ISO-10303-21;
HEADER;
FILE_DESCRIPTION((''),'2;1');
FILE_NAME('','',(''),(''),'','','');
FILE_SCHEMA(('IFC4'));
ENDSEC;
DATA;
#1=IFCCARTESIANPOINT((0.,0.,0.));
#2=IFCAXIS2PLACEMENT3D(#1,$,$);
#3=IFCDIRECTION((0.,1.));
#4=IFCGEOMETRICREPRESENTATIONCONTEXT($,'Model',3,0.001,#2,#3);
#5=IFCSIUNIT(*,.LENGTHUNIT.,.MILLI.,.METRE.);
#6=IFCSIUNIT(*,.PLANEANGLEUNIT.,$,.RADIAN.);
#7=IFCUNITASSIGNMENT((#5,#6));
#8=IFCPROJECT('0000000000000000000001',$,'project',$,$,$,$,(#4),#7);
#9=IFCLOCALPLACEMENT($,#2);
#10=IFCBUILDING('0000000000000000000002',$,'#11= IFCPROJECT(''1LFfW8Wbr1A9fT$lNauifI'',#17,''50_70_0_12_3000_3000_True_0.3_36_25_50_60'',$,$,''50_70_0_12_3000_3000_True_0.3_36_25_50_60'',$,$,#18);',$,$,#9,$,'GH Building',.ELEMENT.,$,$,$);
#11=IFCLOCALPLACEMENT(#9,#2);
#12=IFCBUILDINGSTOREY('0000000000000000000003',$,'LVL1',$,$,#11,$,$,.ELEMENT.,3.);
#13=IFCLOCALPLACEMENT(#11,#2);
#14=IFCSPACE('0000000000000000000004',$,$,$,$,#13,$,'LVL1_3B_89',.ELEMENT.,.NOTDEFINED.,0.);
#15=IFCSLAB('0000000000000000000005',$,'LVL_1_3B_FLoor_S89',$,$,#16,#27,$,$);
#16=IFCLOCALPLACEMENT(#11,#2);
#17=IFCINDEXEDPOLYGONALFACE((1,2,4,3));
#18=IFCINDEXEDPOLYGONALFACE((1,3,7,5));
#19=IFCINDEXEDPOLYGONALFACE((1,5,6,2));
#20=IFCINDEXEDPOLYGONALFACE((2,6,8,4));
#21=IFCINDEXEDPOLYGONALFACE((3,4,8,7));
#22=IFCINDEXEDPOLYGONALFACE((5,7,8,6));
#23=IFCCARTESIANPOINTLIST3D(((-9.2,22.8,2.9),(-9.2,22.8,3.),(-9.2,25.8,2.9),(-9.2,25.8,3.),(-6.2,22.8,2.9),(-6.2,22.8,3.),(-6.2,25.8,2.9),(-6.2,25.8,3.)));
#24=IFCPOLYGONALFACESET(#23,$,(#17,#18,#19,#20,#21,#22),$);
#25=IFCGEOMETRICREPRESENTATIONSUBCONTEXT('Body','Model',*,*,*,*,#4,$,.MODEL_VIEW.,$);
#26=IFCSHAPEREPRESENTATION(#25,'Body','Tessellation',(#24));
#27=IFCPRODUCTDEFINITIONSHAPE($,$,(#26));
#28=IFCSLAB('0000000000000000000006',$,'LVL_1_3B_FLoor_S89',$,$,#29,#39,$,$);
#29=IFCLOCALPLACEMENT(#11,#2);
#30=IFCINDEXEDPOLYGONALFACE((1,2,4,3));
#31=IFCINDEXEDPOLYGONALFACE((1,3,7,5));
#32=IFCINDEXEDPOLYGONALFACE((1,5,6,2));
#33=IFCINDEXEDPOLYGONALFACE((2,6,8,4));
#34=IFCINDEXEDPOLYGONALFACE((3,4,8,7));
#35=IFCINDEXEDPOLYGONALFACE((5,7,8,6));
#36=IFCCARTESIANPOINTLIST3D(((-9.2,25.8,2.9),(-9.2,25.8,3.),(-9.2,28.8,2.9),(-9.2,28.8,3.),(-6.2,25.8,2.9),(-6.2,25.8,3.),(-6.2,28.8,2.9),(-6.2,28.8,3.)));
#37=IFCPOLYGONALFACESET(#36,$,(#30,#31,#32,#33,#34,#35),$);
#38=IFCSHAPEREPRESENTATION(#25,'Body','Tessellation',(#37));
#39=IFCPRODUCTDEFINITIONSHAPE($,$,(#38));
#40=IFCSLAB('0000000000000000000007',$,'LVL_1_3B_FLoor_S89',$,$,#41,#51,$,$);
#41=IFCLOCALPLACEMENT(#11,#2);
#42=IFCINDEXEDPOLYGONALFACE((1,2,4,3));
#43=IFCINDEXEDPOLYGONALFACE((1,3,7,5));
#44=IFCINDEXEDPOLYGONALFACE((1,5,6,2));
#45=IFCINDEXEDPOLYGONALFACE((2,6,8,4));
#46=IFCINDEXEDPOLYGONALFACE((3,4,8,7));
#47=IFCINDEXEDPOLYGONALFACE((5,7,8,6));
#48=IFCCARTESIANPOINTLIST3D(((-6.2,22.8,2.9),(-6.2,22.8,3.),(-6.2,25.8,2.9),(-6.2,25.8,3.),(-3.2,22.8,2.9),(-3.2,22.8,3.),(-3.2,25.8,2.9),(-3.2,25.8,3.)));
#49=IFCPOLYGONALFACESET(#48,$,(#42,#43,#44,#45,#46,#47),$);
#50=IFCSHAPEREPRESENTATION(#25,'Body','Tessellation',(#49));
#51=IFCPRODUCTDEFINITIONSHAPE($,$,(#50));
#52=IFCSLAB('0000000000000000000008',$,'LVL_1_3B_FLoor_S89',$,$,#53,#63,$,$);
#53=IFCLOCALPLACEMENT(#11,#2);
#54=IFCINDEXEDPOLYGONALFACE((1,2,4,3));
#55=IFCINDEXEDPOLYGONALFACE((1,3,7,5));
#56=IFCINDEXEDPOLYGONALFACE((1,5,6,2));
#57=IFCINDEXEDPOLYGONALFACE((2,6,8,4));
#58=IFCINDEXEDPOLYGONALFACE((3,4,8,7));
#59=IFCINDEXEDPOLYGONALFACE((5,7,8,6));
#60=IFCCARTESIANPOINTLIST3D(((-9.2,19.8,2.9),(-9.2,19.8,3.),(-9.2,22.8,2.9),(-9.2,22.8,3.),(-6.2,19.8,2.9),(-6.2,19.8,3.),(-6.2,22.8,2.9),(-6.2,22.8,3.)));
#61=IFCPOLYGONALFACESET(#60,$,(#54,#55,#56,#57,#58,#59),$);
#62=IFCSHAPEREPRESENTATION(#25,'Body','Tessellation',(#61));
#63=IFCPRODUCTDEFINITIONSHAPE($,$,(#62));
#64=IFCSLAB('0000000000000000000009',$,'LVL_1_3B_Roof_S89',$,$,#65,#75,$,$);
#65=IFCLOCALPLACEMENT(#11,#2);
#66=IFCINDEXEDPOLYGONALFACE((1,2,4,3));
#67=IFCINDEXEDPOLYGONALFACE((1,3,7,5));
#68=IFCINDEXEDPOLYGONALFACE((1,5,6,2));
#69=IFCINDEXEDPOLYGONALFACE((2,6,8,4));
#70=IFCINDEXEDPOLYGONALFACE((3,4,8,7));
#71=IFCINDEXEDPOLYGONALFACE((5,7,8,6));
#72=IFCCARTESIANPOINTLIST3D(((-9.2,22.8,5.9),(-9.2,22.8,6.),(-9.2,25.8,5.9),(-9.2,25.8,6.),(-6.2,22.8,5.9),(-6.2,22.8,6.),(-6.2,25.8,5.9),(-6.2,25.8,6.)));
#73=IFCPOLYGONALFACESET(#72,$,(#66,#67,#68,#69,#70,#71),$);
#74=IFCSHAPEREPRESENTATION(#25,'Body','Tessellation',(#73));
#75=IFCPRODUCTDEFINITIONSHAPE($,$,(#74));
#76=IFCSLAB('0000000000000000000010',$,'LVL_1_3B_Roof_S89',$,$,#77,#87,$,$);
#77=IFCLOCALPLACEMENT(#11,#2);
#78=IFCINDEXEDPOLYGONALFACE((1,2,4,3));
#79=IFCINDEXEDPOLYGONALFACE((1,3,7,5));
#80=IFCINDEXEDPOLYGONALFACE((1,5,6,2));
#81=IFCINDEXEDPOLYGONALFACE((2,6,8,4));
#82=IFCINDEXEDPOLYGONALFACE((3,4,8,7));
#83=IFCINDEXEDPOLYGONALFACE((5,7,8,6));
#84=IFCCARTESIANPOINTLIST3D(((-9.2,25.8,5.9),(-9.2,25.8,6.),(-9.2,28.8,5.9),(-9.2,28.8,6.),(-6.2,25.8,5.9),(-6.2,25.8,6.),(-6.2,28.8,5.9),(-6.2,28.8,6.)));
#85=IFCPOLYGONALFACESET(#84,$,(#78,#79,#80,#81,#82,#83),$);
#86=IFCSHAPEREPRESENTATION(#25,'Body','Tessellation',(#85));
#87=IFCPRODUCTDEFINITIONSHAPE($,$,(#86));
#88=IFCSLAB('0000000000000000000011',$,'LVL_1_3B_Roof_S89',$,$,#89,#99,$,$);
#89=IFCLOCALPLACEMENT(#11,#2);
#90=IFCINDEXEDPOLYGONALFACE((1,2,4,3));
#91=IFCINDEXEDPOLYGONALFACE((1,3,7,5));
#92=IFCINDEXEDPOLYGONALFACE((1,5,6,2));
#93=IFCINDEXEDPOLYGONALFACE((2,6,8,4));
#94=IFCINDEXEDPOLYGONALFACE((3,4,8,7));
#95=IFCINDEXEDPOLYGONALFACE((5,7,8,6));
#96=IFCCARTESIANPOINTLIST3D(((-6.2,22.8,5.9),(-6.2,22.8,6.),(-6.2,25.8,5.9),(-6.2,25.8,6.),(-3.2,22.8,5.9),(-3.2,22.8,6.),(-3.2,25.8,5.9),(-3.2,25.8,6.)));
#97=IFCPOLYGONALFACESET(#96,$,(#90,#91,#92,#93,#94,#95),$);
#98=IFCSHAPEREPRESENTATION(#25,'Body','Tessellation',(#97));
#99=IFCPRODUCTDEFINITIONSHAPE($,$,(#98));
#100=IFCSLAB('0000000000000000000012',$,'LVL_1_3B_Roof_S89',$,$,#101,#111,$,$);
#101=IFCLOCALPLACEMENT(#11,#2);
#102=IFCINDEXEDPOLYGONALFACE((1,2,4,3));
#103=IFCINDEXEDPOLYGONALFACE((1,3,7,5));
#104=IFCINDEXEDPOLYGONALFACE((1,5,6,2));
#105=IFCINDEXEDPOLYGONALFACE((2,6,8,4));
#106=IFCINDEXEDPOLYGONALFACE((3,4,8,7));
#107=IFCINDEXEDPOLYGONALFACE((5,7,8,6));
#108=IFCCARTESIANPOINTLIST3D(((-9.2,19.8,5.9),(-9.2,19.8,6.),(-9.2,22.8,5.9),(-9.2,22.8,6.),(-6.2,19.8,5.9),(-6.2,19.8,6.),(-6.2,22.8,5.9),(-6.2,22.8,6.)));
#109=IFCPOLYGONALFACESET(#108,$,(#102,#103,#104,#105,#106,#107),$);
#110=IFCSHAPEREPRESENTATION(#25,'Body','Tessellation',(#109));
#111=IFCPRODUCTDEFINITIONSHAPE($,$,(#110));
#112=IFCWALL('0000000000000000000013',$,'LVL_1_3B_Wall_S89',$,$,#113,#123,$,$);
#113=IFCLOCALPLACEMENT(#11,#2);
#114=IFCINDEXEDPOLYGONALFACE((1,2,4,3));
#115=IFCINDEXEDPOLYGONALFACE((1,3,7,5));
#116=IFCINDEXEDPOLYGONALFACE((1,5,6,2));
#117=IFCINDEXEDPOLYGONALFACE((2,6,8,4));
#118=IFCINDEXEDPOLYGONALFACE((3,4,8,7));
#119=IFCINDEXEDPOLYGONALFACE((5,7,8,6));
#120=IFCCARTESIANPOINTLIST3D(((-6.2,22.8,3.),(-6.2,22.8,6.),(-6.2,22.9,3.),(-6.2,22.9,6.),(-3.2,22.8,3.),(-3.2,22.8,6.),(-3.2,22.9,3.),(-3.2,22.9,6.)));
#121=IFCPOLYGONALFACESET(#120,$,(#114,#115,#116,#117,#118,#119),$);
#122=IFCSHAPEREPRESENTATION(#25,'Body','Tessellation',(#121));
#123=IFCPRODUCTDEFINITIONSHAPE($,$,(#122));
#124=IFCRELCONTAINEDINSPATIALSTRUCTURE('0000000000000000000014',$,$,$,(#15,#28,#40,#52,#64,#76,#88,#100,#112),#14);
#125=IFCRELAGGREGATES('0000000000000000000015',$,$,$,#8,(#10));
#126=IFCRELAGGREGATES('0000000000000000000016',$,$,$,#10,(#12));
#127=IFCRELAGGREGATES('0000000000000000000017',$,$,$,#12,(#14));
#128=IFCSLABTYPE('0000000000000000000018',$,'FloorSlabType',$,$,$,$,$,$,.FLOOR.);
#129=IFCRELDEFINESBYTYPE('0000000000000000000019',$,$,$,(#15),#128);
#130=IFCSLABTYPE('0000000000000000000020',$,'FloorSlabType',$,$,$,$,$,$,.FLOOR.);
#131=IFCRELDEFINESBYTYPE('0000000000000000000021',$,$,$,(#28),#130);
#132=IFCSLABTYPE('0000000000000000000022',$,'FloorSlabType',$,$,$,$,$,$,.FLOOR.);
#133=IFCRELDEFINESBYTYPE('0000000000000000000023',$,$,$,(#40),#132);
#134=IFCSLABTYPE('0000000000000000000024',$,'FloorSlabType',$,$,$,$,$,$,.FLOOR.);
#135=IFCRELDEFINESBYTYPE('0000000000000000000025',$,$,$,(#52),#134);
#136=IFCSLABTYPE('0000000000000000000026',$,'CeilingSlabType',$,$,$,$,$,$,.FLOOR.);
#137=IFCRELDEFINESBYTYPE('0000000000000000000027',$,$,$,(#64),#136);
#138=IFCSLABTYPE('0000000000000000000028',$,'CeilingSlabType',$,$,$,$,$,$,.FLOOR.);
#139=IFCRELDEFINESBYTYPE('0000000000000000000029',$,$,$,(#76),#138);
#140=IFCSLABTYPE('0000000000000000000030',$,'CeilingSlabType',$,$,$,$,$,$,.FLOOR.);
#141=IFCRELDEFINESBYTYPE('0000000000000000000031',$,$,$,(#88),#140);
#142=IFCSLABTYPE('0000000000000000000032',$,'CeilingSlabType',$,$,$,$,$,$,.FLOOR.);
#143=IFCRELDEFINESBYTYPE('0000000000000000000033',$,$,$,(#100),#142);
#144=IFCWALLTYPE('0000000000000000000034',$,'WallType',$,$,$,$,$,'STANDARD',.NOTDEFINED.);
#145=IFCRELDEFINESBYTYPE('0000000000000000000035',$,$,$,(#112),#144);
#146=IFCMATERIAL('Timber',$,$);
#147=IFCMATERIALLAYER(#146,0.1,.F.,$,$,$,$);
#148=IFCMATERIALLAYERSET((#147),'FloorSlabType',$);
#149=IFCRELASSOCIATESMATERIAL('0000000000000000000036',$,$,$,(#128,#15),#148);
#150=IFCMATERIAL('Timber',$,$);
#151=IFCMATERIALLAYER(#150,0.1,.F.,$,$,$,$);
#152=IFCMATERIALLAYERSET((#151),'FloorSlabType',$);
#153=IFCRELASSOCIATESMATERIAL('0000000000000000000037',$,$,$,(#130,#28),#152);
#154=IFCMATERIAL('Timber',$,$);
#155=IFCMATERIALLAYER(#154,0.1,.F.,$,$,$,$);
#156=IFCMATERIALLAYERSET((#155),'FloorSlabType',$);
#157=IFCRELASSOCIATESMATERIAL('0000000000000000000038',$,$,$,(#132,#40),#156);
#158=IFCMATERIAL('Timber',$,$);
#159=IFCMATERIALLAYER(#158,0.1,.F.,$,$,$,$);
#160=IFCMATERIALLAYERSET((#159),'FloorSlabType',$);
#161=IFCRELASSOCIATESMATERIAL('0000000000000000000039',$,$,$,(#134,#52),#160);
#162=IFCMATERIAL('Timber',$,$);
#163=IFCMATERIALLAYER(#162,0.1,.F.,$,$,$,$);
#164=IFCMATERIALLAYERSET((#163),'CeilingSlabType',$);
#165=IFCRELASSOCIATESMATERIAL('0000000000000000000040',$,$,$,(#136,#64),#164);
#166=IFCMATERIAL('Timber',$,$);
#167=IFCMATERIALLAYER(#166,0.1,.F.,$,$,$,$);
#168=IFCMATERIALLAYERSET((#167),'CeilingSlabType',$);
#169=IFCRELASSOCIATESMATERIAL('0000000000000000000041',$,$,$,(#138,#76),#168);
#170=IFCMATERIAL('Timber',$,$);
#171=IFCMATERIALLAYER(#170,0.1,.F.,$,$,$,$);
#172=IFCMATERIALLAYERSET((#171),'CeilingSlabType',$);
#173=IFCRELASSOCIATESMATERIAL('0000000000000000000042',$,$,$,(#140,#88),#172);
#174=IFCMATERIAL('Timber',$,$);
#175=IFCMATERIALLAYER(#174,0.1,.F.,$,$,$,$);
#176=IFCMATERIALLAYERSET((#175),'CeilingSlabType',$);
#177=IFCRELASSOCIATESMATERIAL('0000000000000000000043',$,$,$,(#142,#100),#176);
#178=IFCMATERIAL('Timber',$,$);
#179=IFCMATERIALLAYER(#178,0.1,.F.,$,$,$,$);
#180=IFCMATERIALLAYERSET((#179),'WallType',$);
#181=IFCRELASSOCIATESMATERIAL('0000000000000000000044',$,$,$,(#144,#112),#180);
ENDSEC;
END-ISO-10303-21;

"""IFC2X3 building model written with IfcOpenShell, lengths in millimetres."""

from ifc_helpers import new_model, si_unit, direction, frame, frame_2d, origin, place, context, subcontext, project, spatial, rectangle, extrude, material, layer, layer_set, layer_usage, type_object, element, save


model = new_model("IFC2X3")

# Units and contexts
model_context = context("Model", 3, precision=0.001, world=origin(), true_north=direction((0.0, 1.0)))
body_context = subcontext(model_context, "Body", "Model", "MODEL_VIEW")
ifc_project = project(units=[si_unit("LENGTHUNIT", "METRE", prefix="MILLI"), si_unit("PLANEANGLEUNIT", "RADIAN")], contexts=[model_context])

# Building, storey, space
building_placement = place(None, origin())
building = spatial("IfcBuilding", under=ifc_project, at=building_placement, Name="#11= IFCPROJECT('1LFfW8Wbr1A9fT$lNauifI',#17,'50_70_0_12_3000_3000_True_0.3_36_25_50_60',$,$,'50_70_0_12_3000_3000_True_0.3_36_25_50_60',$,$,#18);", LongName="GH Building", CompositionType="ELEMENT")
storey_placement = place(building_placement, origin())
storey = spatial("IfcBuildingStorey", under=building, at=storey_placement, Name="LVL1", CompositionType="ELEMENT", Elevation=3.0)
space_placement = place(storey_placement, origin())
space = spatial("IfcSpace", under=storey, at=space_placement, LongName="LVL1_3B_89", CompositionType="ELEMENT", InteriorOrExteriorSpace="NOTDEFINED", ElevationWithFlooring=0.0)

# Slabs
ifc_material_1 = material(Name="Timber")
ifc_layer_1 = layer(ifc_material_1, 0.1, ventilated=False)
ifc_layer_set_1 = layer_set([ifc_layer_1], Name="FloorSlabType")
ifc_layer_usage_1 = layer_usage(ifc_layer_set_1, "AXIS3", "NEGATIVE", -0.1)
slab_type_1 = type_object("IfcSlabType", Name="FloorSlabType", PredefinedType="FLOOR", material=ifc_layer_set_1)
slab_1_placement = place(space_placement, frame((-6.2, 22.8, 2.9), z_axis=(0.0, 0.0, 1.0), x_axis=(0.0, 1.0, 0.0)))
element("IfcSlab", 1, at=slab_1_placement, inside=space, type_object=slab_type_1, material=ifc_layer_usage_1, Name="LVL_1_3B_FLoor_S89", context=body_context, shape_type="SweptSolid", body=[
    extrude(rectangle(XDim=3.0, YDim=3.0, at=frame_2d((1.5, 1.5))), origin(), (0.0, 0.0, 1.0), 0.1),
])
ifc_material_2 = material(Name="Timber")
ifc_layer_2 = layer(ifc_material_2, 0.1, ventilated=False)
ifc_layer_set_2 = layer_set([ifc_layer_2], Name="FloorSlabType")
ifc_layer_usage_2 = layer_usage(ifc_layer_set_2, "AXIS3", "NEGATIVE", -0.1)
slab_type_2 = type_object("IfcSlabType", Name="FloorSlabType", PredefinedType="FLOOR", material=ifc_layer_set_2)
slab_2_placement = place(space_placement, frame((-6.2, 25.8, 2.9), z_axis=(0.0, 0.0, 1.0), x_axis=(0.0, 1.0, 0.0)))
element("IfcSlab", 2, at=slab_2_placement, inside=space, type_object=slab_type_2, material=ifc_layer_usage_2, Name="LVL_1_3B_FLoor_S89", context=body_context, shape_type="SweptSolid", body=[
    extrude(rectangle(XDim=3.0, YDim=3.0, at=frame_2d((1.5, 1.5))), origin(), (0.0, 0.0, 1.0), 0.1),
])
ifc_material_3 = material(Name="Timber")
ifc_layer_3 = layer(ifc_material_3, 0.1, ventilated=False)
ifc_layer_set_3 = layer_set([ifc_layer_3], Name="FloorSlabType")
ifc_layer_usage_3 = layer_usage(ifc_layer_set_3, "AXIS3", "NEGATIVE", -0.1)
slab_type_3 = type_object("IfcSlabType", Name="FloorSlabType", PredefinedType="FLOOR", material=ifc_layer_set_3)
slab_3_placement = place(space_placement, frame((-3.2, 22.8, 2.9), z_axis=(0.0, 0.0, 1.0), x_axis=(0.0, 1.0, 0.0)))
element("IfcSlab", 3, at=slab_3_placement, inside=space, type_object=slab_type_3, material=ifc_layer_usage_3, Name="LVL_1_3B_FLoor_S89", context=body_context, shape_type="SweptSolid", body=[
    extrude(rectangle(XDim=3.0, YDim=3.0, at=frame_2d((1.5, 1.5))), origin(), (0.0, 0.0, 1.0), 0.1),
])
ifc_material_4 = material(Name="Timber")
ifc_layer_4 = layer(ifc_material_4, 0.1, ventilated=False)
ifc_layer_set_4 = layer_set([ifc_layer_4], Name="FloorSlabType")
ifc_layer_usage_4 = layer_usage(ifc_layer_set_4, "AXIS3", "NEGATIVE", -0.1)
slab_type_4 = type_object("IfcSlabType", Name="FloorSlabType", PredefinedType="FLOOR", material=ifc_layer_set_4)
slab_4_placement = place(space_placement, frame((-6.2, 19.8, 2.9), z_axis=(0.0, 0.0, 1.0), x_axis=(0.0, 1.0, 0.0)))
element("IfcSlab", 4, at=slab_4_placement, inside=space, type_object=slab_type_4, material=ifc_layer_usage_4, Name="LVL_1_3B_FLoor_S89", context=body_context, shape_type="SweptSolid", body=[
    extrude(rectangle(XDim=3.0, YDim=3.0, at=frame_2d((1.5, 1.5))), origin(), (0.0, 0.0, 1.0), 0.1),
])
ifc_material_5 = material(Name="Timber")
ifc_layer_5 = layer(ifc_material_5, 0.1, ventilated=False)
ifc_layer_set_5 = layer_set([ifc_layer_5], Name="CeilingSlabType")
ifc_layer_usage_5 = layer_usage(ifc_layer_set_5, "AXIS3", "NEGATIVE", -0.1)
slab_type_5 = type_object("IfcSlabType", Name="CeilingSlabType", PredefinedType="FLOOR", material=ifc_layer_set_5)
slab_5_placement = place(space_placement, frame((-6.2, 22.8, 5.9), z_axis=(0.0, 0.0, 1.0), x_axis=(0.0, 1.0, 0.0)))
element("IfcSlab", 5, at=slab_5_placement, inside=space, type_object=slab_type_5, material=ifc_layer_usage_5, Name="LVL_1_3B_Roof_S89", context=body_context, shape_type="SweptSolid", body=[
    extrude(rectangle(XDim=3.0, YDim=3.0, at=frame_2d((1.5, 1.5))), origin(), (0.0, 0.0, 1.0), 0.1),
])
ifc_material_6 = material(Name="Timber")
ifc_layer_6 = layer(ifc_material_6, 0.1, ventilated=False)
ifc_layer_set_6 = layer_set([ifc_layer_6], Name="CeilingSlabType")
ifc_layer_usage_6 = layer_usage(ifc_layer_set_6, "AXIS3", "NEGATIVE", -0.1)
slab_type_6 = type_object("IfcSlabType", Name="CeilingSlabType", PredefinedType="FLOOR", material=ifc_layer_set_6)
slab_6_placement = place(space_placement, frame((-6.2, 25.8, 5.9), z_axis=(0.0, 0.0, 1.0), x_axis=(0.0, 1.0, 0.0)))
element("IfcSlab", 6, at=slab_6_placement, inside=space, type_object=slab_type_6, material=ifc_layer_usage_6, Name="LVL_1_3B_Roof_S89", context=body_context, shape_type="SweptSolid", body=[
    extrude(rectangle(XDim=3.0, YDim=3.0, at=frame_2d((1.5, 1.5))), origin(), (0.0, 0.0, 1.0), 0.1),
])
ifc_material_7 = material(Name="Timber")
ifc_layer_7 = layer(ifc_material_7, 0.1, ventilated=False)
ifc_layer_set_7 = layer_set([ifc_layer_7], Name="CeilingSlabType")
ifc_layer_usage_7 = layer_usage(ifc_layer_set_7, "AXIS3", "NEGATIVE", -0.1)
slab_type_7 = type_object("IfcSlabType", Name="CeilingSlabType", PredefinedType="FLOOR", material=ifc_layer_set_7)
slab_7_placement = place(space_placement, frame((-3.2, 22.8, 5.9), z_axis=(0.0, 0.0, 1.0), x_axis=(0.0, 1.0, 0.0)))
element("IfcSlab", 7, at=slab_7_placement, inside=space, type_object=slab_type_7, material=ifc_layer_usage_7, Name="LVL_1_3B_Roof_S89", context=body_context, shape_type="SweptSolid", body=[
    extrude(rectangle(XDim=3.0, YDim=3.0, at=frame_2d((1.5, 1.5))), origin(), (0.0, 0.0, 1.0), 0.1),
])
ifc_material_8 = material(Name="Timber")
ifc_layer_8 = layer(ifc_material_8, 0.1, ventilated=False)
ifc_layer_set_8 = layer_set([ifc_layer_8], Name="CeilingSlabType")
ifc_layer_usage_8 = layer_usage(ifc_layer_set_8, "AXIS3", "NEGATIVE", -0.1)
slab_type_8 = type_object("IfcSlabType", Name="CeilingSlabType", PredefinedType="FLOOR", material=ifc_layer_set_8)
slab_8_placement = place(space_placement, frame((-6.2, 19.8, 5.9), z_axis=(0.0, 0.0, 1.0), x_axis=(0.0, 1.0, 0.0)))
element("IfcSlab", 8, at=slab_8_placement, inside=space, type_object=slab_type_8, material=ifc_layer_usage_8, Name="LVL_1_3B_Roof_S89", context=body_context, shape_type="SweptSolid", body=[
    extrude(rectangle(XDim=3.0, YDim=3.0, at=frame_2d((1.5, 1.5))), origin(), (0.0, 0.0, 1.0), 0.1),
])

# Wall
ifc_material_9 = material(Name="Timber")
ifc_layer_9 = layer(ifc_material_9, 0.1, ventilated=False)
ifc_layer_set_9 = layer_set([ifc_layer_9], Name="WallType")
ifc_layer_usage_9 = layer_usage(ifc_layer_set_9, "AXIS2", "NEGATIVE", 0.0)
wall_type_1 = type_object("IfcWallType", Name="WallType", ElementType="STANDARD", PredefinedType="NOTDEFINED", material=ifc_layer_set_9)
wall_1_placement = place(space_placement, frame((-3.2, 22.8, 3.0), z_axis=(0.0, 0.0, 1.0), x_axis=(-1.0, 0.0, 0.0)))
element("IfcWall", 9, at=wall_1_placement, inside=space, type_object=wall_type_1, material=ifc_layer_usage_9, Name="LVL_1_3B_Wall_S89", context=body_context, shape_type="SweptSolid", body=[
    extrude(rectangle(XDim=3.0, YDim=0.1, at=frame_2d((1.5, -0.1))), origin(), (0.0, 0.0, 1.0), 3.0),
])

save(model, "model.ifc")
